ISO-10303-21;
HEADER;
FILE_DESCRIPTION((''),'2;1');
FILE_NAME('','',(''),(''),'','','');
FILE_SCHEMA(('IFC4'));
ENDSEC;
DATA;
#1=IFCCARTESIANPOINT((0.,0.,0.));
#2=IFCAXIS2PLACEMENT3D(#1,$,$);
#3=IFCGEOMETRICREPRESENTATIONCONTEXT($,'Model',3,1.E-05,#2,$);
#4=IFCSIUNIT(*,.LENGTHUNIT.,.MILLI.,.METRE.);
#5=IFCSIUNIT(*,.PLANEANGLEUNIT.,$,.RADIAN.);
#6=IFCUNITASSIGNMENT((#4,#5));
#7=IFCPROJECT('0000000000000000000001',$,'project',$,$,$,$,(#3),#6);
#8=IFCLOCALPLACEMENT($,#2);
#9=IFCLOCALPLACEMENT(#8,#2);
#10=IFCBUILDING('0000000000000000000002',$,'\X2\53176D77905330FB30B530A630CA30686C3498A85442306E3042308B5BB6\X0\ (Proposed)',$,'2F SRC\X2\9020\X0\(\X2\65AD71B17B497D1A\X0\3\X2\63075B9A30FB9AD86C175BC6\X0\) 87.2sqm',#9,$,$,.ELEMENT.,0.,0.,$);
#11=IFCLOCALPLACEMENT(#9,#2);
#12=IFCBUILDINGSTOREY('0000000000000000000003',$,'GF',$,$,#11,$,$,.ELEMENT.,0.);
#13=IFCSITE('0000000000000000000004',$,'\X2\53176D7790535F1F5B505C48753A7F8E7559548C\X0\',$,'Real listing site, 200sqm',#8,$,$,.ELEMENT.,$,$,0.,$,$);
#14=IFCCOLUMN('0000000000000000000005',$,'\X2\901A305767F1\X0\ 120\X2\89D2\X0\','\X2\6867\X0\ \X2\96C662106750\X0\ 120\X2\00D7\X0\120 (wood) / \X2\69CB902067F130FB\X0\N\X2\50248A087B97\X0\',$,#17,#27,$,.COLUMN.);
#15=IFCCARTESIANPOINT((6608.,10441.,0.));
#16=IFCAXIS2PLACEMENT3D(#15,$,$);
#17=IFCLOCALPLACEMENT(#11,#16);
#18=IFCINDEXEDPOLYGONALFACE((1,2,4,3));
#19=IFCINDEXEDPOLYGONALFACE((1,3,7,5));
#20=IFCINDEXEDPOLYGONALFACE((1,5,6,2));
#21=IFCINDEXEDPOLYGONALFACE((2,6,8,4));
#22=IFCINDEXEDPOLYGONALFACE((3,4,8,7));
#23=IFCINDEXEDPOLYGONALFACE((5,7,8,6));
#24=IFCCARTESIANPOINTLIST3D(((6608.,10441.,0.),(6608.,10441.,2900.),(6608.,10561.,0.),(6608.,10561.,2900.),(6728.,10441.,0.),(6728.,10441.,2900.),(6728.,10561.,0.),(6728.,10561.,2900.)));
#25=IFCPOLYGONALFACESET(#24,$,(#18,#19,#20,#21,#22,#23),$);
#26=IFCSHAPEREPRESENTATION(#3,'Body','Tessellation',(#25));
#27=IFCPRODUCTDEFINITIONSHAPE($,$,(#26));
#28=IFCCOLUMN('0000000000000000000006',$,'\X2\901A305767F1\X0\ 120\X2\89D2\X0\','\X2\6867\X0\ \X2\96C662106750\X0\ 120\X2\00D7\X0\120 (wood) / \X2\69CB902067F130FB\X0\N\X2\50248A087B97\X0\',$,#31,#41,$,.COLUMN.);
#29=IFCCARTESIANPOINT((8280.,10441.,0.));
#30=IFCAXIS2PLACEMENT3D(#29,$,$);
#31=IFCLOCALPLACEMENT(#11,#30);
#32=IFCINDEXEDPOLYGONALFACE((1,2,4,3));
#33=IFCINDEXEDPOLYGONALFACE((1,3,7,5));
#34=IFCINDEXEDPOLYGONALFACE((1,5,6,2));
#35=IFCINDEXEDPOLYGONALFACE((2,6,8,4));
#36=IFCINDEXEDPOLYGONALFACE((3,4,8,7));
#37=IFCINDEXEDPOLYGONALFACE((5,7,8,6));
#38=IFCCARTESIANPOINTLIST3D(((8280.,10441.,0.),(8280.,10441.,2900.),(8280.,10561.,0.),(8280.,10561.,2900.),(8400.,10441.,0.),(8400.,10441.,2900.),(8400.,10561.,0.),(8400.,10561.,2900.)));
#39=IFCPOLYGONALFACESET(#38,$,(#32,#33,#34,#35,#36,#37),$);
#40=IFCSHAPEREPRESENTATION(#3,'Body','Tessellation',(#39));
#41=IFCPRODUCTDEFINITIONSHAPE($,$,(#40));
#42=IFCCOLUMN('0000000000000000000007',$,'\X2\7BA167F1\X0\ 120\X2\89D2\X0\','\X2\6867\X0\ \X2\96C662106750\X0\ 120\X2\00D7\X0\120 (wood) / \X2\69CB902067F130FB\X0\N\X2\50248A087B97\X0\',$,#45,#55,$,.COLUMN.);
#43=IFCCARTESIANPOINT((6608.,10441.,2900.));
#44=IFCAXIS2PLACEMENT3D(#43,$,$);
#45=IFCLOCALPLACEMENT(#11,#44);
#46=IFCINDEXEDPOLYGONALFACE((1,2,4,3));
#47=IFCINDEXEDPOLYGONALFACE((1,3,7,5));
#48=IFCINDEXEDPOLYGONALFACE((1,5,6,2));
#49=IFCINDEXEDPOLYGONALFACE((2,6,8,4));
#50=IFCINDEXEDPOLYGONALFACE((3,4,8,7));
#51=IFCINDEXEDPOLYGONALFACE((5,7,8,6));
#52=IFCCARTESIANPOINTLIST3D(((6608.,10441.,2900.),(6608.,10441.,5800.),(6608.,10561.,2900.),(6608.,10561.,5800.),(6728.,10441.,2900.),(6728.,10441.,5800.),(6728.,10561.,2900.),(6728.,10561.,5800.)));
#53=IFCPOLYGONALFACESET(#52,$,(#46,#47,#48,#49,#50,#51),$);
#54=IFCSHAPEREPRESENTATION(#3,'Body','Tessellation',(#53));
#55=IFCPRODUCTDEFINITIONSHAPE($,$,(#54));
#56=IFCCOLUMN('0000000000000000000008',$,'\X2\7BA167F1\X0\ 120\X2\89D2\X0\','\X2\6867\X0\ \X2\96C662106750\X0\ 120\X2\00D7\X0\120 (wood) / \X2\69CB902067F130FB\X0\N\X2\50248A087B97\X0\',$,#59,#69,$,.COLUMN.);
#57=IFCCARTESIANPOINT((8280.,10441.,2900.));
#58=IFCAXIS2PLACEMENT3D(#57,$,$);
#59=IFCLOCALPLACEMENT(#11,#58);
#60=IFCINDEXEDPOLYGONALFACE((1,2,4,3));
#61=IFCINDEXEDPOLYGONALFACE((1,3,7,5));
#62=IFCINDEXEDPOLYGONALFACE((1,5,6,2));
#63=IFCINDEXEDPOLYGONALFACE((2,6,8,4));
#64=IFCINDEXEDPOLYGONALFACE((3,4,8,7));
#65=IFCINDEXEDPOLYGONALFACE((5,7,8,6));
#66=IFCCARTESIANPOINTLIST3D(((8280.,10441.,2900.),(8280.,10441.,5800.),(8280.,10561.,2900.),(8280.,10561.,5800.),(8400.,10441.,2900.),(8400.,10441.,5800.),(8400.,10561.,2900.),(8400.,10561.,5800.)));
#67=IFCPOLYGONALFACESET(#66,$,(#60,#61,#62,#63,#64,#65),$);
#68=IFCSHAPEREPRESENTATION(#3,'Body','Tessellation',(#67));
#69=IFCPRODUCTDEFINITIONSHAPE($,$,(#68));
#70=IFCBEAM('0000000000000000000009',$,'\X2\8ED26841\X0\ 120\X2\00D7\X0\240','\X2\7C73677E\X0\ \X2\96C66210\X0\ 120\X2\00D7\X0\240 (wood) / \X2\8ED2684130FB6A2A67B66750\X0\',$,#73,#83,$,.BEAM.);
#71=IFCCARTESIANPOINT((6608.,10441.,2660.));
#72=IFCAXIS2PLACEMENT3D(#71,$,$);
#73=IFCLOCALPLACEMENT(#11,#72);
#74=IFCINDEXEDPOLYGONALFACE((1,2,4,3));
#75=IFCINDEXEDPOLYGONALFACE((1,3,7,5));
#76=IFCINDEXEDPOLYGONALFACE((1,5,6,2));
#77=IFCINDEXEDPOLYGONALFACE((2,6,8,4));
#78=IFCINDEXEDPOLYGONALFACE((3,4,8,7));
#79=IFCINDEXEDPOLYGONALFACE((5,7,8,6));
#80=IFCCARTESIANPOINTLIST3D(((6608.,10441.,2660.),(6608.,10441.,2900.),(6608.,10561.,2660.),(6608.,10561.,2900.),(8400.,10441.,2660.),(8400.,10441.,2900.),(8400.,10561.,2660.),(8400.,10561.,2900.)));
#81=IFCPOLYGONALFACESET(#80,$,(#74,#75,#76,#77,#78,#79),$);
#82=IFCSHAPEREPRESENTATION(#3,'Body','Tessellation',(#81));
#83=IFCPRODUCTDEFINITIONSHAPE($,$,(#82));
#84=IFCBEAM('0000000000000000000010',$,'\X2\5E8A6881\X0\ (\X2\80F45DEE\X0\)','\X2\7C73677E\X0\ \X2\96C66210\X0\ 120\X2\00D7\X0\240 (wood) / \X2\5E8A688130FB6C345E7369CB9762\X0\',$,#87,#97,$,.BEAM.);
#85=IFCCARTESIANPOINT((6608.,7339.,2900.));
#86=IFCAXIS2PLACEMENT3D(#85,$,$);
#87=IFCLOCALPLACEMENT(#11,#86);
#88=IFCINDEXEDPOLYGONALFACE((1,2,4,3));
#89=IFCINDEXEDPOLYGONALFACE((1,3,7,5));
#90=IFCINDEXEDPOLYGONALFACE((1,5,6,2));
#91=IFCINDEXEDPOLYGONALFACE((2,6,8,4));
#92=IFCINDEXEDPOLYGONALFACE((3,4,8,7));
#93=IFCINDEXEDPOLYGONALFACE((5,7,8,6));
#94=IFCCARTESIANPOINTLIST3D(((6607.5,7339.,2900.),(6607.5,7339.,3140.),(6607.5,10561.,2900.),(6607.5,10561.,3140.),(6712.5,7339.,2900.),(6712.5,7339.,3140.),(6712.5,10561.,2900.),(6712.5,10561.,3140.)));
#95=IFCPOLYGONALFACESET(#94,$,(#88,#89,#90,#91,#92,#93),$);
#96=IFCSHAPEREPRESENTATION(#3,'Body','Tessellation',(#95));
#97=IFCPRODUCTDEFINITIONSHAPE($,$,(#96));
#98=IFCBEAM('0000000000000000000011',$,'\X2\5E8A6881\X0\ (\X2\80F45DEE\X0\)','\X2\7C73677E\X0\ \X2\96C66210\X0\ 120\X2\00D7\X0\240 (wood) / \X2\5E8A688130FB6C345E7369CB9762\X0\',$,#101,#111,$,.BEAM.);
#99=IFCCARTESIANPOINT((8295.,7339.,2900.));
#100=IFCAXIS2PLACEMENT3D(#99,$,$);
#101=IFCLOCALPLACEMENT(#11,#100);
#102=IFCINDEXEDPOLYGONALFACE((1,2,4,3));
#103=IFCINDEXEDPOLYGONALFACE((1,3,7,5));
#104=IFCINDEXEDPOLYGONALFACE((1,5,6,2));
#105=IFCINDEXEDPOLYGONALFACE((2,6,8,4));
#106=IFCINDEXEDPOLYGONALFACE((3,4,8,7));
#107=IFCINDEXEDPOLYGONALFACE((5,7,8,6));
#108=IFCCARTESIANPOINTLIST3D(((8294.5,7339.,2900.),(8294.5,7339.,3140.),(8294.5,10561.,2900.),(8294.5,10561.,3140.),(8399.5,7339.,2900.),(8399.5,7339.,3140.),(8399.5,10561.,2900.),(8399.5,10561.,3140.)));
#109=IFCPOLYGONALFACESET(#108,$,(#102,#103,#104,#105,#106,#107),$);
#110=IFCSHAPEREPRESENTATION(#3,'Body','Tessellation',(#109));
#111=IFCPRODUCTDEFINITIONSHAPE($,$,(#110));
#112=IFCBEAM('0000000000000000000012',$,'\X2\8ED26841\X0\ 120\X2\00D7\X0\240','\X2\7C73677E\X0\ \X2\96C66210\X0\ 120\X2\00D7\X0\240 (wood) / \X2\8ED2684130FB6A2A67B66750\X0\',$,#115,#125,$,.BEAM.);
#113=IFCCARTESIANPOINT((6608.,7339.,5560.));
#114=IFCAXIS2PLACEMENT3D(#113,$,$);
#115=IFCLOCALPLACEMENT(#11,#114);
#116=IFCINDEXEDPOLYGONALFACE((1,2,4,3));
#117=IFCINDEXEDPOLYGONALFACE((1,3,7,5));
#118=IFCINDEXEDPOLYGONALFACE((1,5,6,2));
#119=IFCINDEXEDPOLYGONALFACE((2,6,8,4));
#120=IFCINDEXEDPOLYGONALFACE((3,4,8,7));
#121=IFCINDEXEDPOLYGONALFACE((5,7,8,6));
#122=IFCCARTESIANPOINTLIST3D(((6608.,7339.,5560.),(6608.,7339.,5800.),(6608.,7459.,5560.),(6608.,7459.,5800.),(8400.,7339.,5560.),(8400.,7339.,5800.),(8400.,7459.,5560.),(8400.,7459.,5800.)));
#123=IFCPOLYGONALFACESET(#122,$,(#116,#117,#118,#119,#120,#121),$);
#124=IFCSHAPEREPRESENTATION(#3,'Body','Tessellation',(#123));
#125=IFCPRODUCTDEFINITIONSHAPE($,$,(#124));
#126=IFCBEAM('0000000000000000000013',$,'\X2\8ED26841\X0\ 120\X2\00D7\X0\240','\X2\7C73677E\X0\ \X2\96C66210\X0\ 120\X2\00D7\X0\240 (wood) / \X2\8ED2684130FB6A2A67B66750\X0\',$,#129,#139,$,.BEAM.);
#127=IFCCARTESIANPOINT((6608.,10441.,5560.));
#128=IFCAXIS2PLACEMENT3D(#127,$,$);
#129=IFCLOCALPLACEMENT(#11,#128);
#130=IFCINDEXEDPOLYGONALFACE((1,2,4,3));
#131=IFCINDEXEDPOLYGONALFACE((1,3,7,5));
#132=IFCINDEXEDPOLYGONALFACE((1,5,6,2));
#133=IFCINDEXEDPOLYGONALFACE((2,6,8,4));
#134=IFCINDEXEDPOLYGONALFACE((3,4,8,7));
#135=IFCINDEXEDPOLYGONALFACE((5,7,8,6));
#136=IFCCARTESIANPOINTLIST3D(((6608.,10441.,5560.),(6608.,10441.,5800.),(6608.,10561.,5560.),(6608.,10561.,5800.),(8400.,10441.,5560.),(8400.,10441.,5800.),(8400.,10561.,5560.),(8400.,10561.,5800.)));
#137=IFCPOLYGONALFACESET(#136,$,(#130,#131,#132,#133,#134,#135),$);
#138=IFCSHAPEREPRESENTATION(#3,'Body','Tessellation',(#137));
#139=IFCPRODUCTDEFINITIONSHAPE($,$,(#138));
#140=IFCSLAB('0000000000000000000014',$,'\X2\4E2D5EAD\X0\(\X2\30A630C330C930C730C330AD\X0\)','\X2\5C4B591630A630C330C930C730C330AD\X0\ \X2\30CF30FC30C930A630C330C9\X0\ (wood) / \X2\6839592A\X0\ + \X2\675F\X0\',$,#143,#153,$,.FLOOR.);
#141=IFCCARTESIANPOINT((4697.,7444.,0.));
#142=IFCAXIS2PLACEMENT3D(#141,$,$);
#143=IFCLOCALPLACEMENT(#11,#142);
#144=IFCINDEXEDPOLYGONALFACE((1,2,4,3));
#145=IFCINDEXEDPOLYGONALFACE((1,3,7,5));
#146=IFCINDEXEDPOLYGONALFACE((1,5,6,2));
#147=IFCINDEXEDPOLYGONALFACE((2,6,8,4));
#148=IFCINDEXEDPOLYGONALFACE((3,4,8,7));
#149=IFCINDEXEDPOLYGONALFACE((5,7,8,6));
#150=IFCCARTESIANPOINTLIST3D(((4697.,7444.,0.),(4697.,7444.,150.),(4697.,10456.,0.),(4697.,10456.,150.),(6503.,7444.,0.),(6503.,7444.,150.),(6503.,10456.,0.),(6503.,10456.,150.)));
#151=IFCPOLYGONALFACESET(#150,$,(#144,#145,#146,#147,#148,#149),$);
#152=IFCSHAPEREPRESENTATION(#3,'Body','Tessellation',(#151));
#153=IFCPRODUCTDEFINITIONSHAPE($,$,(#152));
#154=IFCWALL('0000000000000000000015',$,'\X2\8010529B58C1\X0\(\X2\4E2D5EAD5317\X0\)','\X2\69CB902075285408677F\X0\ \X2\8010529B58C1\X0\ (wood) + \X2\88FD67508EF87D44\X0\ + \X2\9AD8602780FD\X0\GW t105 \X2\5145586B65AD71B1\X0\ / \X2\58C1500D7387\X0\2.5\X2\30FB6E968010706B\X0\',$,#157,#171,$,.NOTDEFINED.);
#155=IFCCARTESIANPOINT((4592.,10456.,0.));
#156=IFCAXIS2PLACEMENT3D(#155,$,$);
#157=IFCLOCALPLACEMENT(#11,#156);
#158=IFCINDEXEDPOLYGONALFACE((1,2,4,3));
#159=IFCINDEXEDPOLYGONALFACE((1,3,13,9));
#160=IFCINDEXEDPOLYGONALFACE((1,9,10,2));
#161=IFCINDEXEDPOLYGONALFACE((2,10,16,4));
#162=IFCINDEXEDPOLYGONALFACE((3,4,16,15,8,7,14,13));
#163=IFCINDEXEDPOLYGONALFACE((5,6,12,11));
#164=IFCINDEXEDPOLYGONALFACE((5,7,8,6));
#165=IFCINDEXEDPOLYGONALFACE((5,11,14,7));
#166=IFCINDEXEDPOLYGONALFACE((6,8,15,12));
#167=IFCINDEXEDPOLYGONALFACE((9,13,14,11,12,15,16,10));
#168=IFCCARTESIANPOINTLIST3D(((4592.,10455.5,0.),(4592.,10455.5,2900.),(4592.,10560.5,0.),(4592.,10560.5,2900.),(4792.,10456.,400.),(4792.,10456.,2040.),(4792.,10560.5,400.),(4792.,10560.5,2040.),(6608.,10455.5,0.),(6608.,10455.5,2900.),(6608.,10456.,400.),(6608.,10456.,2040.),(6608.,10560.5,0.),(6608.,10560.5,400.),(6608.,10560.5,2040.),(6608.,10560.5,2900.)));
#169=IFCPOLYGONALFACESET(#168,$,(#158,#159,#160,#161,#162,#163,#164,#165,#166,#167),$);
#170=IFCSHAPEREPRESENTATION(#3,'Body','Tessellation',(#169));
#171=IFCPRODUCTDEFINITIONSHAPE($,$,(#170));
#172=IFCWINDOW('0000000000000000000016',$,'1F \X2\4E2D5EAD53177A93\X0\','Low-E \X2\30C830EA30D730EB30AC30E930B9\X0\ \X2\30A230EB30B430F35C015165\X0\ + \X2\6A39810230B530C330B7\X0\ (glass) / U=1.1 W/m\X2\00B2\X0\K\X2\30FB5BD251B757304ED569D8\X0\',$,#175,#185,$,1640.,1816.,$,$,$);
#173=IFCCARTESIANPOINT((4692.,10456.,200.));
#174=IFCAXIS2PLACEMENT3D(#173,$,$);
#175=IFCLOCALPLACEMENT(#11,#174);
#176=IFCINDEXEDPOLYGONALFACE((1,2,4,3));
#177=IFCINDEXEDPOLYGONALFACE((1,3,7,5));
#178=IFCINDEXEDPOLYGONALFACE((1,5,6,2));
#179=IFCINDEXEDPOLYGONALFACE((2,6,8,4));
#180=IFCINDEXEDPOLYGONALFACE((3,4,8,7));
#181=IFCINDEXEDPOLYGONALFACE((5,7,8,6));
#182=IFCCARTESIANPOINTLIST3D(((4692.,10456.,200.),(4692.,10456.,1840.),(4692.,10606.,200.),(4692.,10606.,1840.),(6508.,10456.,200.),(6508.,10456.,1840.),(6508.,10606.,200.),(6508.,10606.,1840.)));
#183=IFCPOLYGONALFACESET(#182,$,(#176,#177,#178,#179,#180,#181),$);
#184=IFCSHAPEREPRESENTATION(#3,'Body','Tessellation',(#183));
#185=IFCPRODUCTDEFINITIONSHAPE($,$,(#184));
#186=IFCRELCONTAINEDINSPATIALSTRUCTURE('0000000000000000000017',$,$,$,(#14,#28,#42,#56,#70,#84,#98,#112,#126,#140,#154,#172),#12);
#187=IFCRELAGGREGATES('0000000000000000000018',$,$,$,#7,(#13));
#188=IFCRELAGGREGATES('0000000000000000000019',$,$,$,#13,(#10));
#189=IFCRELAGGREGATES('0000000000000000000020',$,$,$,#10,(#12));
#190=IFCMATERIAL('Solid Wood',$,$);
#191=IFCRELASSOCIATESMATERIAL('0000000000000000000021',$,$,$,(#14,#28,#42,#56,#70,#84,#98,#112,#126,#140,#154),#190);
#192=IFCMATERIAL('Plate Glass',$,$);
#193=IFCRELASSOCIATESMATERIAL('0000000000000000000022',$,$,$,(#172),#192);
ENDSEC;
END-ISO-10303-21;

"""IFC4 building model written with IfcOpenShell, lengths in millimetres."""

from ifc_helpers import new_model, si_unit, frame, frame_2d, origin, place, context, project, spatial, rectangle, extrude, material, element, fill, save


model = new_model("IFC4")

# Units and contexts
model_context = context("Model", 3, precision=1e-05, world=origin())
ifc_project = project(units=[si_unit("LENGTHUNIT", "METRE", prefix="MILLI"), si_unit("PLANEANGLEUNIT", "RADIAN")], contexts=[model_context])

# Site, building, storey
site_placement = place(None, origin())
site = spatial("IfcSite", under=ifc_project, at=site_placement, Name="北海道弟子屈町美留和", ObjectType="Real listing site, 200sqm", CompositionType="ELEMENT", RefElevation=0.0)
building_placement = place(site_placement, origin())
building = spatial("IfcBuilding", under=site, at=building_placement, Name="北海道・サウナと水風呂のある家 (Proposed)", ObjectType="2F SRC造(断熱等級3指定・高気密) 87.2sqm", CompositionType="ELEMENT", ElevationOfRefHeight=0.0, ElevationOfTerrain=0.0)
storey_placement = place(building_placement, origin())
storey = spatial("IfcBuildingStorey", under=building, at=storey_placement, Name="GF", CompositionType="ELEMENT", Elevation=0.0)

# Columns
ifc_material_1 = material(Name="Solid Wood")
column_1_placement = place(storey_placement, frame((6608.0, 10441.0, 0.0)))
element("IfcColumn", 1, at=column_1_placement, inside=storey, material=ifc_material_1, Name="通し柱 120角", Description="桧 集成材 120×120 (wood) / 構造柱・N値計算", PredefinedType="COLUMN", context=model_context, shape_type="SweptSolid", body=[
    extrude(rectangle(XDim=120.0, YDim=120.0, at=frame_2d((60.0, 60.0))), frame((6608.0, 10441.0, 0.0)), (0.0, 0.0, 1.0), 2900.0),
])
column_2_placement = place(storey_placement, frame((8280.0, 10441.0, 0.0)))
element("IfcColumn", 2, at=column_2_placement, inside=storey, material=ifc_material_1, Name="通し柱 120角", Description="桧 集成材 120×120 (wood) / 構造柱・N値計算", PredefinedType="COLUMN", context=model_context, shape_type="SweptSolid", body=[
    extrude(rectangle(XDim=120.0, YDim=120.0, at=frame_2d((60.0, 60.0))), frame((8280.0, 10441.0, 0.0)), (0.0, 0.0, 1.0), 2900.0),
])
column_3_placement = place(storey_placement, frame((6608.0, 10441.0, 2900.0)))
element("IfcColumn", 3, at=column_3_placement, inside=storey, material=ifc_material_1, Name="管柱 120角", Description="桧 集成材 120×120 (wood) / 構造柱・N値計算", PredefinedType="COLUMN", context=model_context, shape_type="SweptSolid", body=[
    extrude(rectangle(XDim=120.0, YDim=120.0, at=frame_2d((60.0, 60.0))), frame((6608.0, 10441.0, 2900.0)), (0.0, 0.0, 1.0), 2900.0),
])
column_4_placement = place(storey_placement, frame((8280.0, 10441.0, 2900.0)))
element("IfcColumn", 4, at=column_4_placement, inside=storey, material=ifc_material_1, Name="管柱 120角", Description="桧 集成材 120×120 (wood) / 構造柱・N値計算", PredefinedType="COLUMN", context=model_context, shape_type="SweptSolid", body=[
    extrude(rectangle(XDim=120.0, YDim=120.0, at=frame_2d((60.0, 60.0))), frame((8280.0, 10441.0, 2900.0)), (0.0, 0.0, 1.0), 2900.0),
])

# Beams
beam_1_placement = place(storey_placement, frame((6608.0, 10441.0, 2660.0)))
element("IfcBeam", 5, at=beam_1_placement, inside=storey, material=ifc_material_1, Name="軒桁 120×240", Description="米松 集成 120×240 (wood) / 軒桁・横架材", PredefinedType="BEAM", context=model_context, shape_type="SweptSolid", body=[
    extrude(rectangle(XDim=1792.0, YDim=120.0, at=frame_2d((896.0, 60.0))), frame((6608.0, 10441.0, 2660.0)), (0.0, 0.0, 1.0), 240.0),
])
beam_2_placement = place(storey_placement, frame((6608.0, 7339.0, 2900.0)))
element("IfcBeam", 6, at=beam_2_placement, inside=storey, material=ifc_material_1, Name="床梁 (胴差)", Description="米松 集成 120×240 (wood) / 床梁・水平構面", PredefinedType="BEAM", context=model_context, shape_type="SweptSolid", body=[
    extrude(rectangle(XDim=105.0, YDim=3222.0, at=frame_2d((52.0, 1611.0))), frame((6608.0, 7339.0, 2900.0)), (0.0, 0.0, 1.0), 240.0),
])
beam_3_placement = place(storey_placement, frame((8295.0, 7339.0, 2900.0)))
element("IfcBeam", 7, at=beam_3_placement, inside=storey, material=ifc_material_1, Name="床梁 (胴差)", Description="米松 集成 120×240 (wood) / 床梁・水平構面", PredefinedType="BEAM", context=model_context, shape_type="SweptSolid", body=[
    extrude(rectangle(XDim=105.0, YDim=3222.0, at=frame_2d((52.0, 1611.0))), frame((8295.0, 7339.0, 2900.0)), (0.0, 0.0, 1.0), 240.0),
])
beam_4_placement = place(storey_placement, frame((6608.0, 7339.0, 5560.0)))
element("IfcBeam", 8, at=beam_4_placement, inside=storey, material=ifc_material_1, Name="軒桁 120×240", Description="米松 集成 120×240 (wood) / 軒桁・横架材", PredefinedType="BEAM", context=model_context, shape_type="SweptSolid", body=[
    extrude(rectangle(XDim=1792.0, YDim=120.0, at=frame_2d((896.0, 60.0))), frame((6608.0, 7339.0, 5560.0)), (0.0, 0.0, 1.0), 240.0),
])
beam_5_placement = place(storey_placement, frame((6608.0, 10441.0, 5560.0)))
element("IfcBeam", 9, at=beam_5_placement, inside=storey, material=ifc_material_1, Name="軒桁 120×240", Description="米松 集成 120×240 (wood) / 軒桁・横架材", PredefinedType="BEAM", context=model_context, shape_type="SweptSolid", body=[
    extrude(rectangle(XDim=1792.0, YDim=120.0, at=frame_2d((896.0, 60.0))), frame((6608.0, 10441.0, 5560.0)), (0.0, 0.0, 1.0), 240.0),
])

# Slab
slab_placement = place(storey_placement, frame((4697.0, 7444.0, 0.0)))
element("IfcSlab", 10, at=slab_placement, inside=storey, material=ifc_material_1, Name="中庭(ウッドデッキ)", Description="屋外ウッドデッキ ハードウッド (wood) / 根太 + 束", PredefinedType="FLOOR", context=model_context, shape_type="SweptSolid", body=[
    extrude(rectangle(XDim=1806.0, YDim=3012.0, at=frame_2d((903.0, 1506.0))), frame((4697.0, 7444.0, 0.0)), (0.0, 0.0, 1.0), 150.0),
])

# Wall, opening, window
wall_1_placement = place(storey_placement, frame((4592.0, 10456.0, 0.0)))
wall_1 = element("IfcWall", 11, at=wall_1_placement, inside=storey, material=ifc_material_1, Name="耐力壁(中庭北)", Description="構造用合板 耐力壁 (wood) + 製材軸組 + 高性能GW t105 充填断熱 / 壁倍率2.5・準耐火", PredefinedType="NOTDEFINED", context=model_context, shape_type="SweptSolid", body=[
    extrude(rectangle(XDim=2016.0, YDim=105.0, at=frame_2d((1008.0, 52.0))), frame((4592.0, 10456.0, 0.0)), (0.0, 0.0, 1.0), 2900.0),
])
opening_1_placement = place(storey_placement, frame((4692.0, 10456.0, 200.0)))
opening_1 = element("IfcOpeningElement", 12, at=opening_1_placement, cuts=wall_1, PredefinedType="NOTDEFINED", context=model_context, shape_type="SweptSolid", body=[
    extrude(rectangle(XDim=1816.0, YDim=150.0, at=frame_2d((908.0, 75.0))), frame((4692.0, 10456.0, 200.0)), (0.0, 0.0, 1.0), 1640.0),
])
ifc_material_2 = material(Name="Plate Glass")
window_1_placement = place(storey_placement, frame((4692.0, 10456.0, 200.0)))
window_1 = element("IfcWindow", 13, at=window_1_placement, inside=storey, material=ifc_material_2, Name="1F 中庭北窓", Description="Low-E トリプルガラス アルゴン封入 + 樹脂サッシ (glass) / U=1.1 W/m²K・寒冷地仕様", OverallHeight=1640.0, OverallWidth=1816.0, context=model_context, shape_type="SweptSolid", body=[
    extrude(rectangle(XDim=1816.0, YDim=150.0, at=frame_2d((908.0, 75.0))), frame((4692.0, 10456.0, 200.0)), (0.0, 0.0, 1.0), 1640.0),
])
fill(opening_1, window_1)

save(model, "model.ifc")
